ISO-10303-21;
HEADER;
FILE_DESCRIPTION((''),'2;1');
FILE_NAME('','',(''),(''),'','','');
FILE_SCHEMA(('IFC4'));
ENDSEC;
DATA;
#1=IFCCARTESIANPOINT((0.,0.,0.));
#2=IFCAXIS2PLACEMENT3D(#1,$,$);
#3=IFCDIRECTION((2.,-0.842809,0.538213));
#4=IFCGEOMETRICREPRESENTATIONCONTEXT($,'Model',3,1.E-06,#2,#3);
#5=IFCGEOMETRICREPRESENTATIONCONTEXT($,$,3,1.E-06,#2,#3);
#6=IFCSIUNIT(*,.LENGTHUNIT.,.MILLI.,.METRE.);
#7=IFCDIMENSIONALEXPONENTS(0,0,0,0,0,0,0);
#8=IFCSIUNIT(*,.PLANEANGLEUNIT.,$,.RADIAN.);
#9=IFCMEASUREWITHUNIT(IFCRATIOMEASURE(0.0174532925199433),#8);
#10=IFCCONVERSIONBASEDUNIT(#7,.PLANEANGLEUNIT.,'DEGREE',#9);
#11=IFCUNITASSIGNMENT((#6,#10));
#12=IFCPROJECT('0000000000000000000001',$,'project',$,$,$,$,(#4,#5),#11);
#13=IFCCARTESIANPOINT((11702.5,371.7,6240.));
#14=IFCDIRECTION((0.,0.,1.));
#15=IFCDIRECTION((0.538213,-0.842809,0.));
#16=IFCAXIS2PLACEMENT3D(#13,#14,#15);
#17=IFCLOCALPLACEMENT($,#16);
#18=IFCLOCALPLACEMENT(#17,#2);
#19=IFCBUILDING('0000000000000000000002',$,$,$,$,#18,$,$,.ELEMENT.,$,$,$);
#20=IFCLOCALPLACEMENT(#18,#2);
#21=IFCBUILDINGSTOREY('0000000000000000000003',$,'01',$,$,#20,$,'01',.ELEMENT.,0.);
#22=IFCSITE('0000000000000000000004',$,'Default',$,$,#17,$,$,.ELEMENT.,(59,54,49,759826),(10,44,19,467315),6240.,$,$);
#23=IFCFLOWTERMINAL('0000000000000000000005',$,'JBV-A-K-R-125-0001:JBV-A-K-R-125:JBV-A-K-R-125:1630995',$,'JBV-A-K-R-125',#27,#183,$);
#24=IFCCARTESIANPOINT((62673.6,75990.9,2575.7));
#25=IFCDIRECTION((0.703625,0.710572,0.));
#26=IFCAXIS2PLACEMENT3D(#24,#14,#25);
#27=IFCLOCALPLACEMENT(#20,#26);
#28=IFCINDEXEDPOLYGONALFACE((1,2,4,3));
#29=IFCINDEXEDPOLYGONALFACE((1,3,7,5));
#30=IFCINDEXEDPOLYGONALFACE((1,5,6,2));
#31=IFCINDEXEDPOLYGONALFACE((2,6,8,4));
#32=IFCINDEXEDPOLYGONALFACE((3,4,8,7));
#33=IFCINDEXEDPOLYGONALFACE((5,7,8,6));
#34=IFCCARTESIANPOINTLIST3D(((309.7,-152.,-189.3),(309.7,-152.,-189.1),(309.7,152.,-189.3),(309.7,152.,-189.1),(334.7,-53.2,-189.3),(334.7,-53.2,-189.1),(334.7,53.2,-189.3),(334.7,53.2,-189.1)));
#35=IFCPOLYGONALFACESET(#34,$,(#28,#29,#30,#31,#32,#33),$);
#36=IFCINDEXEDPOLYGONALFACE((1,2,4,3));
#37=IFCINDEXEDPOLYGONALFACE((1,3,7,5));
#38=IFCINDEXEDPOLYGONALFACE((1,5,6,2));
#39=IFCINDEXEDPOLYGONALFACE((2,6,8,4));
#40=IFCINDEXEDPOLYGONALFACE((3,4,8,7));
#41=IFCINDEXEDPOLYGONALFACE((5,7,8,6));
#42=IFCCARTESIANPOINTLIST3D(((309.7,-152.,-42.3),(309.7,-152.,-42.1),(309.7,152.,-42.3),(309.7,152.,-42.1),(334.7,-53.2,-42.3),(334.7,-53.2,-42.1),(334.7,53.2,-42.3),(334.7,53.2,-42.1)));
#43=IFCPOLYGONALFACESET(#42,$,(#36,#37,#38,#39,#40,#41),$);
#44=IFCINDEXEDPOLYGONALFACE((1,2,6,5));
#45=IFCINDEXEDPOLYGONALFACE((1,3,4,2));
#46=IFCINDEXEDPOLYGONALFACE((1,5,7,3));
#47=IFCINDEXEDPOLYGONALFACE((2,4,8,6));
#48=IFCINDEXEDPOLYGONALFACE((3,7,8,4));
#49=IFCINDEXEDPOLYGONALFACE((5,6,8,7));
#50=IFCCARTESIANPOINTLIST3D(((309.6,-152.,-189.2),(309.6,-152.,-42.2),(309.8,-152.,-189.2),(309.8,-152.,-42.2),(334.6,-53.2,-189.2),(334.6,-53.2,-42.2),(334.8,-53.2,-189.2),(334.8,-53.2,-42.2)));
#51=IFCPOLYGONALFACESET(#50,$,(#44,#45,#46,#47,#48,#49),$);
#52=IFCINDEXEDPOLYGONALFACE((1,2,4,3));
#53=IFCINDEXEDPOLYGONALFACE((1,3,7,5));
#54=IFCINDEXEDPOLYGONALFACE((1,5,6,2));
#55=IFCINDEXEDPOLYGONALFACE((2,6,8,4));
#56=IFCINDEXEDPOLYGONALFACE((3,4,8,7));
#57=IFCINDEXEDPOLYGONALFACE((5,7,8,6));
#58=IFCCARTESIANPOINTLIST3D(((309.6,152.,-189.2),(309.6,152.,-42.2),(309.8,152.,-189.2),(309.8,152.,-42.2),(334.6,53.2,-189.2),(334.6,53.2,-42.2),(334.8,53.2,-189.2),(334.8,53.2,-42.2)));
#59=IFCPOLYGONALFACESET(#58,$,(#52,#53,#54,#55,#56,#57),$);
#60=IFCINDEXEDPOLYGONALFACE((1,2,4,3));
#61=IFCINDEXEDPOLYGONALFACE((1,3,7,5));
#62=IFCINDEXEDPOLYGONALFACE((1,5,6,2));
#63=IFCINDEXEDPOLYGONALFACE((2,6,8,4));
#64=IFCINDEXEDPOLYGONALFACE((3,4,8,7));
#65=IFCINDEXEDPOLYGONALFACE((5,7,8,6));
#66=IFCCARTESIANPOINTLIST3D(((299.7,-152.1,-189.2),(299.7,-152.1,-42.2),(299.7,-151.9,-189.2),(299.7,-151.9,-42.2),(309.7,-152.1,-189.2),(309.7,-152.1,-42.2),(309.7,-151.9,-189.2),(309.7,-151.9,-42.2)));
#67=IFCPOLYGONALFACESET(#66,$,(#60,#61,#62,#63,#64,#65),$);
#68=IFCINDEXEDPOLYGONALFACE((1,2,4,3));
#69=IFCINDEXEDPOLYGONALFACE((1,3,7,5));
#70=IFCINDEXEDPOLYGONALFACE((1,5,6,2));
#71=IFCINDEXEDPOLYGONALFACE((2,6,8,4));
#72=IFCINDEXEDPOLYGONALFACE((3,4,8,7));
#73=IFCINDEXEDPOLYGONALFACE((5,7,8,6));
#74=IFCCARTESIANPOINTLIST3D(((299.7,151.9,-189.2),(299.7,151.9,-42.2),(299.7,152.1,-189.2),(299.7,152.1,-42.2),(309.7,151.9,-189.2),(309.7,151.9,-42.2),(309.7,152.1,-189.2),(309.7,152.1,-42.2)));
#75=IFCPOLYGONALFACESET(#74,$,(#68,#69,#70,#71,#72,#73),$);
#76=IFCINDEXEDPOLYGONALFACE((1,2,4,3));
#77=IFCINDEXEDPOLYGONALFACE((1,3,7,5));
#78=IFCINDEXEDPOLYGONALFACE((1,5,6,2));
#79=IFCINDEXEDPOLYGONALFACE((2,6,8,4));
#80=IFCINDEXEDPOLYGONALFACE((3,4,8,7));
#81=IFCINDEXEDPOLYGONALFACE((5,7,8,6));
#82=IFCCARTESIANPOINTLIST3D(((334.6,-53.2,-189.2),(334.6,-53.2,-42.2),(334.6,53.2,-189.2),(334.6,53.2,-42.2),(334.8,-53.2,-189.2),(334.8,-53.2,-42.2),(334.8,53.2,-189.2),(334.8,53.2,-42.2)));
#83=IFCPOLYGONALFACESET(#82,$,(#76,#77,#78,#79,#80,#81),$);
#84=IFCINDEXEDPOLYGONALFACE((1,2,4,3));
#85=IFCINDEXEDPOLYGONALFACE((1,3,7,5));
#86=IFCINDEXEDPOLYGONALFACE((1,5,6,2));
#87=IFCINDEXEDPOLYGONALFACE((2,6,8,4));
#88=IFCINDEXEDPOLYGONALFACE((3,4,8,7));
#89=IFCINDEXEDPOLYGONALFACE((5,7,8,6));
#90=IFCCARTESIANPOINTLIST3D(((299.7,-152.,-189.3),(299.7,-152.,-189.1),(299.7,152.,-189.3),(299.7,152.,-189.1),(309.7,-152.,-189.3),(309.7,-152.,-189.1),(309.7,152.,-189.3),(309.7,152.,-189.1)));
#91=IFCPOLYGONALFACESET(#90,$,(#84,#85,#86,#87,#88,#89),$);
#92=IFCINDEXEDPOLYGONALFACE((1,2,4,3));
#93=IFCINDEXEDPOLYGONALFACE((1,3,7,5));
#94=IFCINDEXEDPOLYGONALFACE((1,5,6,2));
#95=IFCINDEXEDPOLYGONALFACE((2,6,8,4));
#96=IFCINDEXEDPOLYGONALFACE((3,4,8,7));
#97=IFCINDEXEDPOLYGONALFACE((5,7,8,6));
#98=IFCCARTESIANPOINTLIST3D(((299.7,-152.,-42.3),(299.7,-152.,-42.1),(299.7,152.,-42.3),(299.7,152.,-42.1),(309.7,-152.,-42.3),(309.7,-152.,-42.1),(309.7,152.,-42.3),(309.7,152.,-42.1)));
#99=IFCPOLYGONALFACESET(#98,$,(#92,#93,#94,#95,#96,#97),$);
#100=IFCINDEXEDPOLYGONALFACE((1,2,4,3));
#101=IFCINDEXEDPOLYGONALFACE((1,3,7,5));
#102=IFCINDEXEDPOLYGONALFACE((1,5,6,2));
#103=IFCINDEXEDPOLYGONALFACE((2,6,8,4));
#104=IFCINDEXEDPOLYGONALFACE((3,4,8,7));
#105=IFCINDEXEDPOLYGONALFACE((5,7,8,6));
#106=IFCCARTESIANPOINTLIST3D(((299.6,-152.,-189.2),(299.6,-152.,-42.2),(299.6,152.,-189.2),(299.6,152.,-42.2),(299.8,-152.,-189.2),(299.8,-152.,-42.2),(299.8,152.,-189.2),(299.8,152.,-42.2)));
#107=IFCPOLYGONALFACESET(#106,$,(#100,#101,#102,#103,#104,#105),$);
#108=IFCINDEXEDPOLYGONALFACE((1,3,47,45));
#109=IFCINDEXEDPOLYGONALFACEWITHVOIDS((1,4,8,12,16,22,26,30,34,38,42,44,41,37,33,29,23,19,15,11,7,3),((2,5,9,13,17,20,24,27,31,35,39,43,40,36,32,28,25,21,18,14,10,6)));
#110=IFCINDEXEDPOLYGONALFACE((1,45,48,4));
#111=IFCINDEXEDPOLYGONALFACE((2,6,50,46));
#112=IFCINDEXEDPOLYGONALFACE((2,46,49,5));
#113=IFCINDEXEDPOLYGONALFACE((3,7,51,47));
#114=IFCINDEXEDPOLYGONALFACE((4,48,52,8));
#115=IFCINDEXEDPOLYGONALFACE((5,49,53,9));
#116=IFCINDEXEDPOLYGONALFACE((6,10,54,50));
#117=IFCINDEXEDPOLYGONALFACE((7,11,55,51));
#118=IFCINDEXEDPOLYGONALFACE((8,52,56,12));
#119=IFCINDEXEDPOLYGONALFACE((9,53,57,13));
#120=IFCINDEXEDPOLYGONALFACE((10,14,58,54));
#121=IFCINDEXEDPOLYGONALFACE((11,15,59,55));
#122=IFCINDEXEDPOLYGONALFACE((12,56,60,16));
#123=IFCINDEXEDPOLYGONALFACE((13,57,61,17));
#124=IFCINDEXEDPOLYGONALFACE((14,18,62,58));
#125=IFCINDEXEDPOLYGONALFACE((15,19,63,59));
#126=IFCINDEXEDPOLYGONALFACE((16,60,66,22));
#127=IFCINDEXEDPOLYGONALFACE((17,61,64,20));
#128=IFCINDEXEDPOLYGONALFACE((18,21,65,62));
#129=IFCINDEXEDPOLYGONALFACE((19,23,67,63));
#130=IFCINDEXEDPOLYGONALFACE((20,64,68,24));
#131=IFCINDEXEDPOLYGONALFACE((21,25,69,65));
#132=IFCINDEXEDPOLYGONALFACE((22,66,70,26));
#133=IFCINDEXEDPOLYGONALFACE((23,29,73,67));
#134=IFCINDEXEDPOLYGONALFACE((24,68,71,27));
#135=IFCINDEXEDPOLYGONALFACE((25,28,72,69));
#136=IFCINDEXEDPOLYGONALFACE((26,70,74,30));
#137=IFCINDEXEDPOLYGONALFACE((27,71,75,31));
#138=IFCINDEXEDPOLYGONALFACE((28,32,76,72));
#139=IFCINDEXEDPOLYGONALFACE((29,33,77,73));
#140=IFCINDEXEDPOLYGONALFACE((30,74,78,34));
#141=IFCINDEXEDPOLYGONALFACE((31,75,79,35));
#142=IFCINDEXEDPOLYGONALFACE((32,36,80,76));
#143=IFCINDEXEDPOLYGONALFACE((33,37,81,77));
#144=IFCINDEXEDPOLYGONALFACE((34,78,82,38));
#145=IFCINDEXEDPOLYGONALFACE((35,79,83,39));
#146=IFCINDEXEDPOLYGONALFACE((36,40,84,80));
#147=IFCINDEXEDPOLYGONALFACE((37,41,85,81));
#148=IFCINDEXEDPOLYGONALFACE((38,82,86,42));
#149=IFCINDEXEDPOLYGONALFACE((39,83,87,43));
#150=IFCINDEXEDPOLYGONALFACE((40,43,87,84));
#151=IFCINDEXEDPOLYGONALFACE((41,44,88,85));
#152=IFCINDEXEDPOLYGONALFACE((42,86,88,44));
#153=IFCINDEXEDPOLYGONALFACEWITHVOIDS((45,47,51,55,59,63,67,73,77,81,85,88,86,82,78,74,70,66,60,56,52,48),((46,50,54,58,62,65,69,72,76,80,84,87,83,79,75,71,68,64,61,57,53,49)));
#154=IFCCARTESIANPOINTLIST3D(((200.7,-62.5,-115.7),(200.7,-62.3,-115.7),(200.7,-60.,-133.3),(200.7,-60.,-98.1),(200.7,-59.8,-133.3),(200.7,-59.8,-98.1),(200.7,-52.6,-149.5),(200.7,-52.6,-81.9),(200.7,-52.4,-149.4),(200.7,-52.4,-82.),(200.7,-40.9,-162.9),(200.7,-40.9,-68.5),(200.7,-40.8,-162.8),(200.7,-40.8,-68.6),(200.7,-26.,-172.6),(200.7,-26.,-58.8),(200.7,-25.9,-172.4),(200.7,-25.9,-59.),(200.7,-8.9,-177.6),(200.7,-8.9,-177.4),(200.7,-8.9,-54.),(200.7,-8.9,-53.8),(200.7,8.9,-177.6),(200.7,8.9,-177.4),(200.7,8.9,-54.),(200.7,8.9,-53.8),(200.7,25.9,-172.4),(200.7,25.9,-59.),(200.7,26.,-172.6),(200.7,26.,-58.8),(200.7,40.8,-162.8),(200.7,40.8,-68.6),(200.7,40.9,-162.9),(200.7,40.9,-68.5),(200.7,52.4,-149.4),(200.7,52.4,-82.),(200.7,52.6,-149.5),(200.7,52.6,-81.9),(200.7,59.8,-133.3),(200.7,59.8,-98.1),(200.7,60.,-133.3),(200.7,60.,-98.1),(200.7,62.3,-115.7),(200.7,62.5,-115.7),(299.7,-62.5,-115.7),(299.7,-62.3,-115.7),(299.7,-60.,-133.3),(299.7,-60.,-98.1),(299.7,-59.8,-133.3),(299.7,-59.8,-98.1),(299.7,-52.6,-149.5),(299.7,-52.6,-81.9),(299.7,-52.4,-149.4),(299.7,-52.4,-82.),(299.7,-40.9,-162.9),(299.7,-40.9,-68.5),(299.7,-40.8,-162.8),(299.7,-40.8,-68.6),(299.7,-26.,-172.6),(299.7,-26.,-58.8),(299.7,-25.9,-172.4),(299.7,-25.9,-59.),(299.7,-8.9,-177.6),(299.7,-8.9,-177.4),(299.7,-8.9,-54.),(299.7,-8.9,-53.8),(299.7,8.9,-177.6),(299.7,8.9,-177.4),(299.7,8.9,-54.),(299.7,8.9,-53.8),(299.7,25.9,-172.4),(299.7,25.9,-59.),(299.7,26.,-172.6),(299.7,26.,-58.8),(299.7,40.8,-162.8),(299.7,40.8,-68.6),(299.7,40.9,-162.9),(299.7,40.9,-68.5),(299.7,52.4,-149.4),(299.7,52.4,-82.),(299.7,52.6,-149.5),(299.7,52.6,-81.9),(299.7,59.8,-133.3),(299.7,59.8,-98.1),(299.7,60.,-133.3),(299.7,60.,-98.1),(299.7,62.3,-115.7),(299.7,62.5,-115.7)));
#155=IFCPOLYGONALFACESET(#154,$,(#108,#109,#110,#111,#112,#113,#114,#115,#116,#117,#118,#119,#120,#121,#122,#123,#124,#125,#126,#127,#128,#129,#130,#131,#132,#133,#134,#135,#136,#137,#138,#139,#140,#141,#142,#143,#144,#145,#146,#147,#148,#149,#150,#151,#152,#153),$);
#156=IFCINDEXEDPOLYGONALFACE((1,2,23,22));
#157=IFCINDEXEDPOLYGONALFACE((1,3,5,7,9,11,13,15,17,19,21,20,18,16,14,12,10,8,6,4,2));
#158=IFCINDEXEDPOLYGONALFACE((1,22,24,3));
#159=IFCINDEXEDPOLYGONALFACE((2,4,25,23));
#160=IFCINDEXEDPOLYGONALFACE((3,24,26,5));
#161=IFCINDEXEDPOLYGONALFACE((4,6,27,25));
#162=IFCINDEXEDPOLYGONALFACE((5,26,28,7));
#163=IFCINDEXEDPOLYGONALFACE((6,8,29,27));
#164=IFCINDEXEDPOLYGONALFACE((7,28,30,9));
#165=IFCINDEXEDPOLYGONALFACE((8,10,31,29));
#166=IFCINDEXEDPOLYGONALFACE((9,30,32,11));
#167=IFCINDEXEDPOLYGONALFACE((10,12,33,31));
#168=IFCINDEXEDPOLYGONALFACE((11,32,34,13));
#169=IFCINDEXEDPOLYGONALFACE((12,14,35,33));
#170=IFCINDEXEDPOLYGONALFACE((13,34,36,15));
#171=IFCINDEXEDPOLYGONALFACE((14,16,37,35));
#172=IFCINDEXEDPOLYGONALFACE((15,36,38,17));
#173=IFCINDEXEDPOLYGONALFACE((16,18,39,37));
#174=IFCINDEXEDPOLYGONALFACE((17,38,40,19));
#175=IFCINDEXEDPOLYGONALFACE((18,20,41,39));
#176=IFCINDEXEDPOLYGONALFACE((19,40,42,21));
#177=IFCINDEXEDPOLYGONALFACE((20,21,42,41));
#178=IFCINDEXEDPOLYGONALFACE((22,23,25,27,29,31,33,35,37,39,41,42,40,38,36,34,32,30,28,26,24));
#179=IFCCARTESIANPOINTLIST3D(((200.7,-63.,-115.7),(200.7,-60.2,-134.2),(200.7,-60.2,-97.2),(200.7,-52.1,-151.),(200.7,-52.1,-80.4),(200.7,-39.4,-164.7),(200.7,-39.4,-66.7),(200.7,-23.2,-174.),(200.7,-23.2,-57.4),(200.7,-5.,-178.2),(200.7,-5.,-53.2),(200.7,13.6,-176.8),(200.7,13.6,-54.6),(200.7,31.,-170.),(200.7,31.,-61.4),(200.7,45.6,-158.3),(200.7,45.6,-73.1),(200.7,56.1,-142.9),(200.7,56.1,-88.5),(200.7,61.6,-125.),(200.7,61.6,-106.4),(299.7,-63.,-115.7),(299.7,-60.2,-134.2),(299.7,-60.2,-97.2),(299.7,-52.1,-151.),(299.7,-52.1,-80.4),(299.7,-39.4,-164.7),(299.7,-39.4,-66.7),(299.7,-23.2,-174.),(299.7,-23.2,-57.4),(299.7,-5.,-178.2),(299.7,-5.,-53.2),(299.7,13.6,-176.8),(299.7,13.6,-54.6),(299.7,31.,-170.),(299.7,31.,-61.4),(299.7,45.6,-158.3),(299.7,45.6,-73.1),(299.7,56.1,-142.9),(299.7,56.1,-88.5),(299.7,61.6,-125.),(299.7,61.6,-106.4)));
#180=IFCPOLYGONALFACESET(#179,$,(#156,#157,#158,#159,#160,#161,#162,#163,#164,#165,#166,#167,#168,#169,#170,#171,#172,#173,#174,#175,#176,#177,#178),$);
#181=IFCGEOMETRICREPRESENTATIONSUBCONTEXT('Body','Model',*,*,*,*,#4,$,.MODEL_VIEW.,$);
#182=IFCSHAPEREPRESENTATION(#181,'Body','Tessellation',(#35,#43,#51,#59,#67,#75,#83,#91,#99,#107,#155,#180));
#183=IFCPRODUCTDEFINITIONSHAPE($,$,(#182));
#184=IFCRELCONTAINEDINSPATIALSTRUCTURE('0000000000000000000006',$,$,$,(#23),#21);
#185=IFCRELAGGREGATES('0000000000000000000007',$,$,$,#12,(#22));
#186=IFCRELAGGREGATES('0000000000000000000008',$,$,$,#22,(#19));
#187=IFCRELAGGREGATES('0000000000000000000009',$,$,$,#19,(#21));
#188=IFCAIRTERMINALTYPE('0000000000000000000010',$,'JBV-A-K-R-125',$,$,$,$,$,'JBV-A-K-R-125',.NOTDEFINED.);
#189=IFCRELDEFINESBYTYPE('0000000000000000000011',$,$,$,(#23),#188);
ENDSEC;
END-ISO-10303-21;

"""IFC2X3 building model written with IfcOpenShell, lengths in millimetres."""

from ifc_helpers import new_model, entity, si_unit, converted_unit, direction, frame, frame_2d, origin, origin_2d_with_axis, place, context, subcontext, project, spatial, polyline, circle_curve, parameter, trimmed, segment, composite_curve, rectangle, circle, outline, extrude, source, transform, mapped, type_object, type_shapes, element, save


model = new_model("IFC2X3")

# Units and contexts
model_context = context("Model", 3, precision=1e-06, world=origin(), true_north=direction((2.0, -0.842809, 0.538213)))
context_of_model = context(None, 3, precision=1e-06, world=origin(), true_north=direction((2.0, -0.842809, 0.538213)))
body_context = subcontext(model_context, "Body", "Model", "MODEL_VIEW")
ifc_project = project(units=[si_unit("LENGTHUNIT", "METRE", prefix="MILLI"), converted_unit("PLANEANGLEUNIT", "DEGREE", entity("IfcRatioMeasure", 0.0174532925199433), si_unit("PLANEANGLEUNIT", "RADIAN"), dimensions=[0, 0, 0, 0, 0, 0, 0])], contexts=[model_context, context_of_model])

# Site, building, storey
site_placement = place(None, frame((11702.5, 371.7, 6240.0), z_axis=(0.0, 0.0, 1.0), x_axis=(0.538213, -0.842809, 0.0)))
site = spatial("IfcSite", under=ifc_project, at=site_placement, Name="Default", CompositionType="ELEMENT", RefLatitude=(59, 54, 49, 759826), RefLongitude=(10, 44, 19, 467315), RefElevation=6240.0)
building_placement = place(site_placement, origin())
building = spatial("IfcBuilding", under=site, at=building_placement, CompositionType="ELEMENT")
storey_placement = place(building_placement, origin())
storey = spatial("IfcBuildingStorey", under=building, at=storey_placement, Name="01", LongName="01", CompositionType="ELEMENT", Elevation=0.0)

# Flow terminal
air_terminal_type_1 = type_object("IfcAirTerminalType", Name="JBV-A-K-R-125", ElementType="JBV-A-K-R-125", PredefinedType="NOTDEFINED")
shared_shape_1 = source(origin(), body_context, "Body", "SweptSolid", [
    extrude(outline(polyline([(-150.4, -25.2), (-48.5, -25.2), (54.6, 0.9), (144.3, 49.4), (-150.4, -25.2)])), frame((322.2, 0.0, -189.3), z_axis=(0.0, 0.0, 1.0), x_axis=(0.245305, 0.969446, 0.0)), (0.0, 0.0, 1.0), 0.2),
    extrude(outline(polyline([(-150.4, -25.2), (-48.5, -25.2), (54.6, 0.9), (144.3, 49.4), (-150.4, -25.2)])), frame((322.2, 0.0, -42.3), z_axis=(0.0, 0.0, 1.0), x_axis=(0.245305, 0.969446, 0.0)), (0.0, 0.0, 1.0), 0.2),
    extrude(rectangle(XDim=101.9, YDim=0.2, at=frame_2d((0.0, 0.0), x_axis=(1.0, 0.0))), frame((322.2, -102.6, -189.2), z_axis=(0.0, 0.0, 1.0), x_axis=(-0.245305, -0.969446, 0.0)), (0.0, 0.0, 1.0), 147.0),
    extrude(rectangle(XDim=101.9, YDim=0.2, at=frame_2d((0.0, 0.0), x_axis=(1.0, 0.0))), frame((322.2, 102.6, -189.2), z_axis=(0.0, 0.0, 1.0), x_axis=(-0.245305, 0.969446, 0.0)), (0.0, 0.0, 1.0), 147.0),
    extrude(rectangle(XDim=10.0, YDim=0.2, at=frame_2d((0.0, 0.0), x_axis=(1.0, 0.0))), frame((304.7, -152.0, -189.2), z_axis=(0.0, 0.0, 1.0), x_axis=(-1.0, 0.0, 0.0)), (0.0, 0.0, 1.0), 147.0),
    extrude(rectangle(XDim=10.0, YDim=0.2, at=frame_2d((0.0, 0.0), x_axis=(1.0, 0.0))), frame((304.7, 152.0, -189.2), z_axis=(0.0, 0.0, 1.0), x_axis=(-1.0, 0.0, 0.0)), (0.0, 0.0, 1.0), 147.0),
    extrude(rectangle(XDim=106.4, YDim=0.2, at=frame_2d((0.0, 0.0), x_axis=(1.0, 0.0))), frame((334.7, 0.0, -189.2), z_axis=(0.0, 0.0, 1.0), x_axis=(0.0, -1.0, 0.0)), (0.0, 0.0, 1.0), 147.0),
    extrude(rectangle(XDim=10.0, YDim=304.0, at=frame_2d((0.0, 0.0), x_axis=(1.0, 0.0))), frame((304.7, 0.0, -189.3)), (0.0, 0.0, 1.0), 0.2),
    extrude(rectangle(XDim=10.0, YDim=304.0, at=frame_2d((0.0, 0.0), x_axis=(1.0, 0.0))), frame((304.7, 0.0, -42.3)), (0.0, 0.0, 1.0), 0.2),
    extrude(rectangle(XDim=304.0, YDim=0.2, at=frame_2d((0.0, 0.0), x_axis=(1.0, 0.0))), frame((299.7, 0.0, -189.2), z_axis=(0.0, 0.0, 1.0), x_axis=(0.0, -1.0, 0.0)), (0.0, 0.0, 1.0), 147.0),
    extrude(outline(composite_curve([segment(trimmed(circle_curve(origin_2d_with_axis(), 62.5), [parameter(0.0)], [parameter(180.0)], True, "PARAMETER"), True, "CONTINUOUS"), segment(trimmed(circle_curve(origin_2d_with_axis(), 62.5), [parameter(180.0)], [parameter(0.0)], True, "PARAMETER"), True, "CONTINUOUS")], self_intersect=False), holes=[composite_curve([segment(trimmed(circle_curve(origin_2d_with_axis(), 62.3), [parameter(180.0)], [parameter(360.0)], True, "PARAMETER"), False, "CONTINUOUS"), segment(trimmed(circle_curve(origin_2d_with_axis(), 62.3), [parameter(0.0)], [parameter(180.0)], True, "PARAMETER"), False, "CONTINUOUS")], self_intersect=False)]), frame((200.7, 0.0, -115.7), z_axis=(1.0, 0.0, 0.0), x_axis=(0.0, -1.0, 0.0)), (0.0, 0.0, 1.0), 99.0),
    extrude(circle(Radius=62.6, at=frame_2d((0.0, 0.0), x_axis=(1.0, 0.0))), frame((200.7, -0.3, -115.7), z_axis=(1.0, 0.0, 0.0), x_axis=(0.0, -1.0, 0.0)), (0.0, 0.0, 1.0), 99.0),
])
type_shapes(air_terminal_type_1, [shared_shape_1])
for number, where, z_axis, x_axis, name in (
    (1, (62673.6, 75990.9, 2575.7), (0.0, 0.0, 1.0), (0.703625, 0.710572, 0.0), "JBV-A-K-R-125-0001:JBV-A-K-R-125:JBV-A-K-R-125:1630995"),
):
    element("IfcFlowTerminal", number, at=place(storey_placement, frame(where, z_axis=z_axis, x_axis=x_axis)), inside=storey, type_object=air_terminal_type_1, Name=name, ObjectType="JBV-A-K-R-125", context=body_context, shape_type="MappedRepresentation", body=[
        mapped(shared_shape_1, transform((0.0, 0.0, 0.0), scale=1.0)),
    ])

save(model, "model.ifc")
